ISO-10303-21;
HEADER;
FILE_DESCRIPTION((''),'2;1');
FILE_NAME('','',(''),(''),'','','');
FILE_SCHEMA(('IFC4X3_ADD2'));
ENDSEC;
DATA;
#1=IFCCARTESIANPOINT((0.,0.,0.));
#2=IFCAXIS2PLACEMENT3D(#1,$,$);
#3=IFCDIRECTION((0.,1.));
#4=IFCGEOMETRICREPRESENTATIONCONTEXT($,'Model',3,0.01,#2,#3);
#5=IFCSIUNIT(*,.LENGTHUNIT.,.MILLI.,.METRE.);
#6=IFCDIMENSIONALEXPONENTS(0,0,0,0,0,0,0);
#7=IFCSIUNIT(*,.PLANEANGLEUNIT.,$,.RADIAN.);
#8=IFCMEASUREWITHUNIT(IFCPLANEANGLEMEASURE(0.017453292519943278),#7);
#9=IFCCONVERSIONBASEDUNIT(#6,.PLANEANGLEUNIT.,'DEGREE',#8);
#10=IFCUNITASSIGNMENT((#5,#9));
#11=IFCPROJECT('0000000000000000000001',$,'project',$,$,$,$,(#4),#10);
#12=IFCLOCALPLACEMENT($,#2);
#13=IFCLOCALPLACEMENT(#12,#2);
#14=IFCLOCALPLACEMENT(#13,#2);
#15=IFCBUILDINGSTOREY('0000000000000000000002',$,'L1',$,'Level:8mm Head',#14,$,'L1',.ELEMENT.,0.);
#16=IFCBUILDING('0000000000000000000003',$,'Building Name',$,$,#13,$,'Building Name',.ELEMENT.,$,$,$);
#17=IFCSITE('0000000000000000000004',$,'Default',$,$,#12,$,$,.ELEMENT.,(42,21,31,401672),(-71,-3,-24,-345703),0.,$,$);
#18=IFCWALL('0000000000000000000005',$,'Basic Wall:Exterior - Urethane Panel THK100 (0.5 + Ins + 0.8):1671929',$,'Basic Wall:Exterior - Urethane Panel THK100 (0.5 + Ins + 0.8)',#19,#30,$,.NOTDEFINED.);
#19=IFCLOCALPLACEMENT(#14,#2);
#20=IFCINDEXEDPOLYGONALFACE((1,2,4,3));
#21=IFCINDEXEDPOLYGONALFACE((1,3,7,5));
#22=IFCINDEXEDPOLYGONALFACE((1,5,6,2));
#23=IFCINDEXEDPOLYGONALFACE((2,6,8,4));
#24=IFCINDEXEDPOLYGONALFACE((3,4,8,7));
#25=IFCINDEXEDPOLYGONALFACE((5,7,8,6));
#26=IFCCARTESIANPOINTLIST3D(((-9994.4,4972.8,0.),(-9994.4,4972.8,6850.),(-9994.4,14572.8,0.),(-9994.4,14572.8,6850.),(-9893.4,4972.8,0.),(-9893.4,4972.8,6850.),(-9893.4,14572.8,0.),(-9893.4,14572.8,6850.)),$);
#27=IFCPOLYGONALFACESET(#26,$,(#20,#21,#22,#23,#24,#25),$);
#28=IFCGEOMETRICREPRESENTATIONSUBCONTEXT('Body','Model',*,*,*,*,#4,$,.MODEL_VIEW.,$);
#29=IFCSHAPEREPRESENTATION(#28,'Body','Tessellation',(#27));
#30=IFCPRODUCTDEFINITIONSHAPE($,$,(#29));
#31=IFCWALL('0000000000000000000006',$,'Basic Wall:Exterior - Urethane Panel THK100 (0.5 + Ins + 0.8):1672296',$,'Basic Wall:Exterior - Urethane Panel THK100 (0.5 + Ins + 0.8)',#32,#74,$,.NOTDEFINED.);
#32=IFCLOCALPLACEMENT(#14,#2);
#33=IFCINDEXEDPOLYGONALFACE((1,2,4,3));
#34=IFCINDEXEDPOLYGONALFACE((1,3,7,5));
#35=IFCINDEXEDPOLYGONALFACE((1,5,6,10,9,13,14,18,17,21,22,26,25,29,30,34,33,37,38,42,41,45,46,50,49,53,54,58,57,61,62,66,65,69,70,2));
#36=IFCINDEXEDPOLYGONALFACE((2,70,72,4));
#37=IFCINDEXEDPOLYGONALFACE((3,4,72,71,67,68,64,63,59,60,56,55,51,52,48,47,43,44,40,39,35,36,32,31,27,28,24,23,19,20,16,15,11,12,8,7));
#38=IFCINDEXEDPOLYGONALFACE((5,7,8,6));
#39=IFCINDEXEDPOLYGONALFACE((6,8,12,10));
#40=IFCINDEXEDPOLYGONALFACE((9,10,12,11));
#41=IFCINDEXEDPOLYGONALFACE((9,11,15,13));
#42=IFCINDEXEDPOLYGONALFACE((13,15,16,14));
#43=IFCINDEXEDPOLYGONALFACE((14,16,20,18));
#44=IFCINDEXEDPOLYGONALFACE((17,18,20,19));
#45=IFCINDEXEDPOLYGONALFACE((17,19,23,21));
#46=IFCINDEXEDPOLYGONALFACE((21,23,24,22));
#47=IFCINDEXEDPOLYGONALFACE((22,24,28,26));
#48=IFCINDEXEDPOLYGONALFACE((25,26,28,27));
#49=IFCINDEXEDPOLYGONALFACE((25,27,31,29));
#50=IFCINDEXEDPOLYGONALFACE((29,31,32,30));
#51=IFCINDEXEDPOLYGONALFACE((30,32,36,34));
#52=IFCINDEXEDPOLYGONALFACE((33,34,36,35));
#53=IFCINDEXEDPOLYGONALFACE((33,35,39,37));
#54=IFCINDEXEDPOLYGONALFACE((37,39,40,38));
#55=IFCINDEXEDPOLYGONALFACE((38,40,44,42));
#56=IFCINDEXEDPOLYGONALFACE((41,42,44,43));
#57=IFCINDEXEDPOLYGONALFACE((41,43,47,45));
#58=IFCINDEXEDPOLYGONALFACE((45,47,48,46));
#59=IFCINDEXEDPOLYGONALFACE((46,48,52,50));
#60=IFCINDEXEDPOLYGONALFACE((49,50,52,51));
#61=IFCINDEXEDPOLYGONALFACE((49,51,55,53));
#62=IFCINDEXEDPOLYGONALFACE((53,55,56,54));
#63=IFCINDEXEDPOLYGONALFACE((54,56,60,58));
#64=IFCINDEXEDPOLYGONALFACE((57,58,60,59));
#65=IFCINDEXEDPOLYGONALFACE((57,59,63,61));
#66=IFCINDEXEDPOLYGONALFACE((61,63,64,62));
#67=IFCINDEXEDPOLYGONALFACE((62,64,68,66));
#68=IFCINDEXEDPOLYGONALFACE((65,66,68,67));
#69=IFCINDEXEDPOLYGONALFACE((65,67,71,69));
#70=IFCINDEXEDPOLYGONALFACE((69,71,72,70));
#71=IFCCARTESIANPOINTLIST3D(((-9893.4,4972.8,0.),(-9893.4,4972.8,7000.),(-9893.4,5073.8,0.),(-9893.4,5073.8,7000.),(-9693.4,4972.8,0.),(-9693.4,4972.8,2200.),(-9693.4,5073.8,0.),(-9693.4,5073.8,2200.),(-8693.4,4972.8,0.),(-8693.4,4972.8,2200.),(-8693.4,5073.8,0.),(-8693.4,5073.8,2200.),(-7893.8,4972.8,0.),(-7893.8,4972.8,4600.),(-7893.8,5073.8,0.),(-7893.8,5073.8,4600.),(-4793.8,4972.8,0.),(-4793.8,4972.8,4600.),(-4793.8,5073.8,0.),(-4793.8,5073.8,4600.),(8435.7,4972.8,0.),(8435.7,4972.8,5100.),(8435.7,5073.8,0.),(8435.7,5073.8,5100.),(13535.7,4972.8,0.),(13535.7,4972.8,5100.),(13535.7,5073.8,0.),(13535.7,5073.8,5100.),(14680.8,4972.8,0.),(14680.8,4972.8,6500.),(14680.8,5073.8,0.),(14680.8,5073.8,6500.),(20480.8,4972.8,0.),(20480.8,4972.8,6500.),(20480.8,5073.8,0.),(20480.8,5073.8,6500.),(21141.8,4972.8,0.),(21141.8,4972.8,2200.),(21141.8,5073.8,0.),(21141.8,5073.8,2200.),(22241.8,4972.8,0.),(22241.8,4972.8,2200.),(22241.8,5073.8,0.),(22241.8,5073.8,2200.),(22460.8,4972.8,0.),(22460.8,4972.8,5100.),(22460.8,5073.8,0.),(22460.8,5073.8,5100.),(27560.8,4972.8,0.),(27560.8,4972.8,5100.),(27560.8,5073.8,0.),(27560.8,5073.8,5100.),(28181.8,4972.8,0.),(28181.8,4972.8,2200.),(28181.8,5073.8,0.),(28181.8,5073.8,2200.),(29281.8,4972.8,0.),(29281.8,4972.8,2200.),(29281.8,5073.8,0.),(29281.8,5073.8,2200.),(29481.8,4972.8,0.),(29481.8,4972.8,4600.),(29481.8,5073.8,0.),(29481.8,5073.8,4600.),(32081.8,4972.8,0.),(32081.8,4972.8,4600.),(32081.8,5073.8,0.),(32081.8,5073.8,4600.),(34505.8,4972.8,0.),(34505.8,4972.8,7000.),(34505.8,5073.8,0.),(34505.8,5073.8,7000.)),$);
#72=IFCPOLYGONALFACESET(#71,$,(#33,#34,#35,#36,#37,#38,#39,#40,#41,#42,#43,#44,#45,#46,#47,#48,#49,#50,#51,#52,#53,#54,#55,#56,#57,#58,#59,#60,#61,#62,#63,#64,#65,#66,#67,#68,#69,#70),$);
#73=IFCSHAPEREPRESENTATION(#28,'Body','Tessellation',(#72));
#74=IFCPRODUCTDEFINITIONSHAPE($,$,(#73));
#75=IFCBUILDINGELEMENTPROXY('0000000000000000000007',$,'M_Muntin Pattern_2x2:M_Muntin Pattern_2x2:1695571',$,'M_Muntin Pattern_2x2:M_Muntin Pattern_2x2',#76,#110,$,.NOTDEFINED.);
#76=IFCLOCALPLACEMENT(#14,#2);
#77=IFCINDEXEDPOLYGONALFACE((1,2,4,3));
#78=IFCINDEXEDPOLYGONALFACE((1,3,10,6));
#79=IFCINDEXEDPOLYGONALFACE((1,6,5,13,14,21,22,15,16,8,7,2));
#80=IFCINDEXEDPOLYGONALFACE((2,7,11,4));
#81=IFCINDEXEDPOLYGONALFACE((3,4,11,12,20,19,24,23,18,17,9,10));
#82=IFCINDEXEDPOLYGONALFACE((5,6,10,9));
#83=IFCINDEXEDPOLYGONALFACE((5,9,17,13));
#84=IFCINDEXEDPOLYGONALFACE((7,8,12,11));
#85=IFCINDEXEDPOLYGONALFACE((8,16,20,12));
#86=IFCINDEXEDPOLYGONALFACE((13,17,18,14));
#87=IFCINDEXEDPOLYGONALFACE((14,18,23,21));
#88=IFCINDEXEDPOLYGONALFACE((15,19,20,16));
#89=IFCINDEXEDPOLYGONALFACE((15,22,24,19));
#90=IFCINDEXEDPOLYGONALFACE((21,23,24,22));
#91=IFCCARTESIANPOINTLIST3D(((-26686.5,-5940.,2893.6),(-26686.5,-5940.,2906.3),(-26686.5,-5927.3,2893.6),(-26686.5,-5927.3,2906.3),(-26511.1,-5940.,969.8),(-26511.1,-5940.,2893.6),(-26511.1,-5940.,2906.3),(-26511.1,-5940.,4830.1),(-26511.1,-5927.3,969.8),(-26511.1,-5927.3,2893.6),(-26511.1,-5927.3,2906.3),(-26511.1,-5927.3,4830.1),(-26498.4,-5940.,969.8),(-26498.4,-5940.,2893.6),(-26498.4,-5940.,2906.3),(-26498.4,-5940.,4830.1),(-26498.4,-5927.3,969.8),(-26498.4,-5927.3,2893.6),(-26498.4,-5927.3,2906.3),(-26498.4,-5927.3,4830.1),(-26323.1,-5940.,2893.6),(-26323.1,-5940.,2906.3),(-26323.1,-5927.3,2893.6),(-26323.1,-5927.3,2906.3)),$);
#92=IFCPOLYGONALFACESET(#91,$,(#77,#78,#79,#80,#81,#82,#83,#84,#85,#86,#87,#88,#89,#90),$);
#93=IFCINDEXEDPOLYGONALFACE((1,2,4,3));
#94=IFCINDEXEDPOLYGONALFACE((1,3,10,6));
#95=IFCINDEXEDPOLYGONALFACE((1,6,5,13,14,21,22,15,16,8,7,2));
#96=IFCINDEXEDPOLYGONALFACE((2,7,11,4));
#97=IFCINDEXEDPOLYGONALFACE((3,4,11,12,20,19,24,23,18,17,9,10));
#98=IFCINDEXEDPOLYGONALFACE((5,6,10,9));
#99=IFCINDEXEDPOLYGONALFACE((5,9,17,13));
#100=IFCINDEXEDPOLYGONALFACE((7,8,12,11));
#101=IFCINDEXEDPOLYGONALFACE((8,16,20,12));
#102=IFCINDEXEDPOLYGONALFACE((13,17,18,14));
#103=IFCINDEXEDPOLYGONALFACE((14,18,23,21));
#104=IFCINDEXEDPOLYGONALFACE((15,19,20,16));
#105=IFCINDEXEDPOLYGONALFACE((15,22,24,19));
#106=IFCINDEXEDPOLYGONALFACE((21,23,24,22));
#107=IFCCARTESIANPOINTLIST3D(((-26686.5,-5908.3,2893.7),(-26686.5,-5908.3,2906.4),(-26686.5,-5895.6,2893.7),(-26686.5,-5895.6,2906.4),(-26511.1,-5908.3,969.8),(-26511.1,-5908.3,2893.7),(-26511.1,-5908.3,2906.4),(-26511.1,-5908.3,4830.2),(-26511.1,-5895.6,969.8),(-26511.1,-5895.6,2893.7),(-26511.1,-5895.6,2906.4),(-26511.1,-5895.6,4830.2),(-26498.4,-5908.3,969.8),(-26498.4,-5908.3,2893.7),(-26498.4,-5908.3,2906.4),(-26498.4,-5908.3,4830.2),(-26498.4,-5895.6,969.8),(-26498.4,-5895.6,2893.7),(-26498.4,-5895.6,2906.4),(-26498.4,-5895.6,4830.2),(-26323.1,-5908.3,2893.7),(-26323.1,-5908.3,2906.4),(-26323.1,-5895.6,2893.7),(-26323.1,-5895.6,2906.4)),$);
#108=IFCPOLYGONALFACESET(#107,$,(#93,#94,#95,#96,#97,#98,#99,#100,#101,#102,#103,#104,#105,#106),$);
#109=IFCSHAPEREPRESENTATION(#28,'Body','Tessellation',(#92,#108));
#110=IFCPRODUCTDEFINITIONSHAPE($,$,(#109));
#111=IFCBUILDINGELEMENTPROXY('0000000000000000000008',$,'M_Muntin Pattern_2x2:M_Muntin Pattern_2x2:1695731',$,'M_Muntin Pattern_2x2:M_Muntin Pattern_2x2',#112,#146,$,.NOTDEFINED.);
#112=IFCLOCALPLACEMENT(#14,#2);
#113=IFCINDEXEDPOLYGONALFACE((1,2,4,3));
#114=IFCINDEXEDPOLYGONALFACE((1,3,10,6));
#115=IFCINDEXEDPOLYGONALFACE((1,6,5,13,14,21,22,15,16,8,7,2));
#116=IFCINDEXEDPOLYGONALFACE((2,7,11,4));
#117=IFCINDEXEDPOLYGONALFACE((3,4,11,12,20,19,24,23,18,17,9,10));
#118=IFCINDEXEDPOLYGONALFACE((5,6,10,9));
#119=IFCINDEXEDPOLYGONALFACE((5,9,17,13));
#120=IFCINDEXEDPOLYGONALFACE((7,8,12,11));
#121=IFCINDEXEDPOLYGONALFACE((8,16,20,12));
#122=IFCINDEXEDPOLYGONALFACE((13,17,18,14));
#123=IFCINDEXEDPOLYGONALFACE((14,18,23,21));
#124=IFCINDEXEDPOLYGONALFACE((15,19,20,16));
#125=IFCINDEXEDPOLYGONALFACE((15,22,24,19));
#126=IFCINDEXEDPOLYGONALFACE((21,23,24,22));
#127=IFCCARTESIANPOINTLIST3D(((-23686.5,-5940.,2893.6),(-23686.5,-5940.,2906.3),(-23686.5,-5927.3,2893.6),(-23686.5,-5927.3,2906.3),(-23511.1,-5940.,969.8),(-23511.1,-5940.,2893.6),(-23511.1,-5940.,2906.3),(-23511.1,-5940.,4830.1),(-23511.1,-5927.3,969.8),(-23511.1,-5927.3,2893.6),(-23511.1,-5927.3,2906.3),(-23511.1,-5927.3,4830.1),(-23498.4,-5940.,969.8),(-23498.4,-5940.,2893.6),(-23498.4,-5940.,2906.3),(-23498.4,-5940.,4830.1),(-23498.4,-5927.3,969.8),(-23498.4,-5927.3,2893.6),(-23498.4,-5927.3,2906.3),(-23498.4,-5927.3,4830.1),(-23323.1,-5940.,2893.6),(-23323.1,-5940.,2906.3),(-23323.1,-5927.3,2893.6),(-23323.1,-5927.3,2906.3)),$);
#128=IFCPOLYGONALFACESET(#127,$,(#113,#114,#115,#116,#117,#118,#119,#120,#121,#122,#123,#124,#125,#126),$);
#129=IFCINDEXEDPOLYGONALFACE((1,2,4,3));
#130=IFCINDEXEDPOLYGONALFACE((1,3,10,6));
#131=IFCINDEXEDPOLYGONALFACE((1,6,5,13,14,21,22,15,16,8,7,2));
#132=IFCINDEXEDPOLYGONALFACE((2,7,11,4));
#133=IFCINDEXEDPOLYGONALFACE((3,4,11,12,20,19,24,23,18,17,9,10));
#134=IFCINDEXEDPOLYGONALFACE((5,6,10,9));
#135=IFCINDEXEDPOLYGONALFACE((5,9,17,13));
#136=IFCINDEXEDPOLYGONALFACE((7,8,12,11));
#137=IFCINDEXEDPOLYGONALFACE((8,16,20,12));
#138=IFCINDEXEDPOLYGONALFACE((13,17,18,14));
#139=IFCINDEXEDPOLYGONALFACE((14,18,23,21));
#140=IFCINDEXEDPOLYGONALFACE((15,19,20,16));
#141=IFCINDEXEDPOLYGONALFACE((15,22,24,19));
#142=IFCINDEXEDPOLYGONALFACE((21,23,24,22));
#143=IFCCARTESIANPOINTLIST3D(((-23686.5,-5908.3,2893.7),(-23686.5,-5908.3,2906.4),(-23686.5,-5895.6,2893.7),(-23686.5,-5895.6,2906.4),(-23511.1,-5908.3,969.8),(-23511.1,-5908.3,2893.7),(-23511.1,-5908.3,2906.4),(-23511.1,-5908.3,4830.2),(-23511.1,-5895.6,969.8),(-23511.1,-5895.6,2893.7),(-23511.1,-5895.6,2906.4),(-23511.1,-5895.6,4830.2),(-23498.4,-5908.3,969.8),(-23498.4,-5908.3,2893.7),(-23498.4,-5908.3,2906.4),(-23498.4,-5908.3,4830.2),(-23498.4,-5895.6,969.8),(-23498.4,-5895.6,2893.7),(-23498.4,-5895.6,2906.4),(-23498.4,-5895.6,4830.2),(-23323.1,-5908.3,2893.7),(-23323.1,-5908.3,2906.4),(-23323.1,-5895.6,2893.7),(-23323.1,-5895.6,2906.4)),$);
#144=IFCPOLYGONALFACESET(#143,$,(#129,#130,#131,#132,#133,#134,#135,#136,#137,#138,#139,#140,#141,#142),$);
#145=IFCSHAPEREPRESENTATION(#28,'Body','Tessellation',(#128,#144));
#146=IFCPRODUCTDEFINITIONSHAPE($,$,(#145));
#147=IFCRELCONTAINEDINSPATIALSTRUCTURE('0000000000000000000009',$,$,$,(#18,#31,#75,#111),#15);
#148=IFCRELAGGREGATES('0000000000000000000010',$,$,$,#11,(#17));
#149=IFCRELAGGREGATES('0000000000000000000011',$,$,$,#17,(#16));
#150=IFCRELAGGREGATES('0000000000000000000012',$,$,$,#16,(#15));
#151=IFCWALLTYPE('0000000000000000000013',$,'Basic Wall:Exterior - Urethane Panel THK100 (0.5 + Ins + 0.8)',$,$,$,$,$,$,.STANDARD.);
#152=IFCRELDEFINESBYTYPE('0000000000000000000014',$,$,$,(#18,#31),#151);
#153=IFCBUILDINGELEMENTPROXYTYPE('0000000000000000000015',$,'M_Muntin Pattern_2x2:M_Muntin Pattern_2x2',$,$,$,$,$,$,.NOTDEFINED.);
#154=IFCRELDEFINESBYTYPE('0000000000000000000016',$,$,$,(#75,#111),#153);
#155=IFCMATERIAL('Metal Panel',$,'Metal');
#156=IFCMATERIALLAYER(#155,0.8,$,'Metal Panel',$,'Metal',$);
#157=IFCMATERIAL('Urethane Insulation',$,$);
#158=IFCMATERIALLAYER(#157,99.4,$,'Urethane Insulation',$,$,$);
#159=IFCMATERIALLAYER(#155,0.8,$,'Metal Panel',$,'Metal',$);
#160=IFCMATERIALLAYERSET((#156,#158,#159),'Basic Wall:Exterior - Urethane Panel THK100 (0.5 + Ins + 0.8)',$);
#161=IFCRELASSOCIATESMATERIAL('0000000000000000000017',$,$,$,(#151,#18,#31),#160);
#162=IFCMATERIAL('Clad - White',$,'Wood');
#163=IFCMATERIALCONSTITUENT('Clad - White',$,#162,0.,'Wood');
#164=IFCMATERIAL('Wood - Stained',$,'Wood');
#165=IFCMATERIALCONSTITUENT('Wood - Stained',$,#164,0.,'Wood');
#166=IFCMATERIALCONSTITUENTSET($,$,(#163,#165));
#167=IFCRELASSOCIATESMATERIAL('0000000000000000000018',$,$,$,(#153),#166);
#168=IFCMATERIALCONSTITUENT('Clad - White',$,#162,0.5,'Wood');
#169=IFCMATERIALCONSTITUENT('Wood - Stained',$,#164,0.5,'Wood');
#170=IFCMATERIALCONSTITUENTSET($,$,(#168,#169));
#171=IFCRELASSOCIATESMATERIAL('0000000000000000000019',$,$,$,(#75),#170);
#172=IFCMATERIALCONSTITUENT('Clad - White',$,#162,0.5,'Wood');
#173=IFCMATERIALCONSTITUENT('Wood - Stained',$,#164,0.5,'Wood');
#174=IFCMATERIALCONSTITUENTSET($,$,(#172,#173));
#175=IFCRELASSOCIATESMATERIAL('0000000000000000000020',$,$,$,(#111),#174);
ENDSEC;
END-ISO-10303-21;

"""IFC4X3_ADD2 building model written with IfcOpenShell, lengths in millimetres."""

from ifc_helpers import new_model, entity, si_unit, converted_unit, direction, frame, frame_2d, origin, place, context, subcontext, project, spatial, polyline, rectangle, outline, extrude, clip, bounded_halfspace, source, transform, mapped, material, layer, layer_set, constituent, constituent_set, type_object, type_shapes, element, save


model = new_model("IFC4X3_ADD2")

# Units and contexts
model_context = context("Model", 3, precision=0.01, world=origin(), true_north=direction((0.0, 1.0)))
body_context = subcontext(model_context, "Body", "Model", "MODEL_VIEW")
ifc_project = project(units=[si_unit("LENGTHUNIT", "METRE", prefix="MILLI"), converted_unit("PLANEANGLEUNIT", "DEGREE", entity("IfcPlaneAngleMeasure", 0.017453292519943278), si_unit("PLANEANGLEUNIT", "RADIAN"), dimensions=[0, 0, 0, 0, 0, 0, 0])], contexts=[model_context])

# Site, building, storey
site_placement = place(None, origin())
site = spatial("IfcSite", under=ifc_project, at=site_placement, Name="Default", CompositionType="ELEMENT", RefLatitude=(42, 21, 31, 401672), RefLongitude=(-71, -3, -24, -345703), RefElevation=0.0)
building_placement = place(site_placement, origin())
building = spatial("IfcBuilding", under=site, at=building_placement, Name="Building Name", LongName="Building Name", CompositionType="ELEMENT")
storey_placement = place(building_placement, origin())
storey = spatial("IfcBuildingStorey", under=building, at=storey_placement, Name="L1", ObjectType="Level:8mm Head", LongName="L1", CompositionType="ELEMENT", Elevation=0.0)

# Wall
ifc_material_1 = material(Name="Metal Panel", Category="Metal")
ifc_layer_1 = layer(ifc_material_1, 0.8, Name="Metal Panel", Category="Metal")
ifc_material_2 = material(Name="Urethane Insulation")
ifc_layer_2 = layer(ifc_material_2, 99.4, Name="Urethane Insulation")
ifc_layer_3 = layer(ifc_material_1, 0.8, Name="Metal Panel", Category="Metal")
ifc_layer_set = layer_set([ifc_layer_1, ifc_layer_2, ifc_layer_3], Name="Basic Wall:Exterior - Urethane Panel THK100 (0.5 + Ins + 0.8)")
wall_type = type_object("IfcWallType", Name="Basic Wall:Exterior - Urethane Panel THK100 (0.5 + Ins + 0.8)", PredefinedType="STANDARD", material=ifc_layer_set)
wall_1_placement = place(storey_placement, frame((-9943.9, 4972.8, 0.0), z_axis=(0.0, 0.0, 1.0), x_axis=(0.0, 1.0, 0.0)))
element("IfcWall", 1, at=wall_1_placement, inside=storey, type_object=wall_type, material=ifc_layer_set, Name="Basic Wall:Exterior - Urethane Panel THK100 (0.5 + Ins + 0.8):1671929", ObjectType="Basic Wall:Exterior - Urethane Panel THK100 (0.5 + Ins + 0.8)", PredefinedType="NOTDEFINED", context=body_context, shape_type="Clipping", body=[
    clip(extrude(rectangle(XDim=9600.0, YDim=101.0, at=frame_2d((4800.0, 0.0), x_axis=(-1.0, 0.0))), origin(), (0.0, 0.0, 1.0), 6850.0), bounded_halfspace(frame((0.0, -50.5, 6850.0), z_axis=(0.0, 0.0, -1.0), x_axis=(0.0, -1.0, 0.0)), True, frame((0.0, -50.5, 6850.0)), polyline([(0.0, 0.0), (9600.0, 0.0), (9600.0, 101.0), (0.0, 101.0), (0.0, 0.0)]))),
])

# Wall, openings
wall_2_placement = place(storey_placement, frame((-9893.4, 5023.3, 0.0)))
wall_2 = element("IfcWall", 2, at=wall_2_placement, inside=storey, type_object=wall_type, material=ifc_layer_set, Name="Basic Wall:Exterior - Urethane Panel THK100 (0.5 + Ins + 0.8):1672296", ObjectType="Basic Wall:Exterior - Urethane Panel THK100 (0.5 + Ins + 0.8)", PredefinedType="NOTDEFINED", context=body_context, shape_type="SweptSolid", body=[
    extrude(rectangle(XDim=44399.2, YDim=101.0, at=frame_2d((22199.6, 0.0), x_axis=(-1.0, 0.0))), origin(), (0.0, 0.0, 1.0), 7000.0),
])
opening_1_placement = place(wall_2_placement, frame((200.0, -50.5, 0.0)))
element("IfcOpeningElement", 3, at=opening_1_placement, cuts=wall_2, PredefinedType="OPENING", context=body_context, shape_type="SweptSolid", body=[
    extrude(rectangle(XDim=2200.0, YDim=1000.0, at=frame_2d((1100.0, 500.0), x_axis=(1.0, 0.0))), frame((0.0, 0.0, 0.0), z_axis=(0.0, 1.0, 0.0), x_axis=(0.0, 0.0, 1.0)), (0.0, 0.0, 1.0), 101.0),
])
opening_2_placement = place(wall_2_placement, frame((39175.2, 50.5, 0.0)))
element("IfcOpeningElement", 4, at=opening_2_placement, cuts=wall_2, PredefinedType="OPENING", context=body_context, shape_type="SweptSolid", body=[
    extrude(rectangle(XDim=2200.0, YDim=1100.0, at=frame_2d((1100.0, 550.0), x_axis=(1.0, 0.0))), frame((0.0, 0.0, 0.0), z_axis=(0.0, -1.0, 0.0), x_axis=(0.0, 0.0, 1.0)), (0.0, 0.0, 1.0), 101.0),
])
opening_3_placement = place(wall_2_placement, frame((32135.2, 50.5, 0.0)))
element("IfcOpeningElement", 5, at=opening_3_placement, cuts=wall_2, PredefinedType="OPENING", context=body_context, shape_type="SweptSolid", body=[
    extrude(rectangle(XDim=2200.0, YDim=1100.0, at=frame_2d((1100.0, 550.0), x_axis=(1.0, 0.0))), frame((0.0, 0.0, 0.0), z_axis=(0.0, -1.0, 0.0), x_axis=(0.0, 0.0, 1.0)), (0.0, 0.0, 1.0), 101.0),
])
opening_4_placement = place(wall_2_placement, frame((18329.1, -50.5, 0.0)))
element("IfcOpeningElement", 6, at=opening_4_placement, cuts=wall_2, PredefinedType="OPENING", context=body_context, shape_type="SweptSolid", body=[
    extrude(rectangle(XDim=5100.0, YDim=5100.0, at=frame_2d((2550.0, 2550.0), x_axis=(1.0, 0.0))), frame((0.0, 0.0, 0.0), z_axis=(0.0, 1.0, 0.0), x_axis=(0.0, 0.0, 1.0)), (0.0, 0.0, 1.0), 101.0),
])
opening_5_placement = place(wall_2_placement, frame((37454.2, 50.5, 0.0)))
element("IfcOpeningElement", 7, at=opening_5_placement, cuts=wall_2, PredefinedType="OPENING", context=body_context, shape_type="SweptSolid", body=[
    extrude(rectangle(XDim=5100.0, YDim=5100.0, at=frame_2d((2550.0, 2550.0), x_axis=(1.0, 0.0))), frame((0.0, 0.0, 0.0), z_axis=(0.0, -1.0, 0.0), x_axis=(0.0, 0.0, 1.0)), (0.0, 0.0, 1.0), 101.0),
])
opening_6_placement = place(wall_2_placement, frame((41975.2, 50.5, 0.0)))
element("IfcOpeningElement", 8, at=opening_6_placement, cuts=wall_2, PredefinedType="OPENING", context=body_context, shape_type="SweptSolid", body=[
    extrude(rectangle(XDim=4600.0, YDim=2600.0, at=frame_2d((2300.0, 1300.0), x_axis=(1.0, 0.0))), frame((0.0, 0.0, 0.0), z_axis=(0.0, -1.0, 0.0), x_axis=(0.0, 0.0, 1.0)), (0.0, 0.0, 1.0), 101.0),
])
opening_7_placement = place(wall_2_placement, frame((5099.6, 50.5, 0.0)))
element("IfcOpeningElement", 9, at=opening_7_placement, cuts=wall_2, PredefinedType="OPENING", context=body_context, shape_type="SweptSolid", body=[
    extrude(rectangle(XDim=4600.0, YDim=3100.0, at=frame_2d((2300.0, 1550.0), x_axis=(1.0, 0.0))), frame((0.0, 0.0, 0.0), z_axis=(0.0, -1.0, 0.0), x_axis=(0.0, 0.0, 1.0)), (0.0, 0.0, 1.0), 101.0),
])
opening_8_placement = place(wall_2_placement, frame((30374.2, 50.5, 0.0)))
element("IfcOpeningElement", 10, at=opening_8_placement, cuts=wall_2, PredefinedType="OPENING", context=body_context, shape_type="SweptSolid", body=[
    extrude(rectangle(XDim=6500.0, YDim=5800.0, at=frame_2d((3250.0, 2900.0), x_axis=(-1.0, 0.0))), frame((0.0, 0.0, 0.0), z_axis=(0.0, -1.0, 0.0), x_axis=(0.0, 0.0, 1.0)), (0.0, 0.0, 1.0), 101.0),
])

# Building element proxies
ifc_material_3 = material(Name="Clad - White", Category="Wood")
ifc_constituent_1 = constituent(ifc_material_3, Name="Clad - White", Category="Wood", fraction=0.5)
ifc_material_4 = material(Name="Wood - Stained", Category="Wood")
ifc_constituent_2 = constituent(ifc_material_4, Name="Wood - Stained", Category="Wood", fraction=0.5)
ifc_constituent_set_1 = constituent_set(constituents=[ifc_constituent_1, ifc_constituent_2])
ifc_constituent_3 = constituent(ifc_material_3, Name="Clad - White", Category="Wood", fraction=0.0)
ifc_constituent_4 = constituent(ifc_material_4, Name="Wood - Stained", Category="Wood", fraction=0.0)
ifc_constituent_set_2 = constituent_set(constituents=[ifc_constituent_3, ifc_constituent_4])
building_element_proxy_type_1 = type_object("IfcBuildingElementProxyType", Name="M_Muntin Pattern_2x2:M_Muntin Pattern_2x2", PredefinedType="NOTDEFINED", material=ifc_constituent_set_2)
shared_shape_1 = source(origin(), body_context, "Body", "SweptSolid", [
    extrude(outline(polyline([(6.4, -6.4), (1930.1, -6.4), (1930.1, 6.3), (6.4, 6.3), (6.4, 181.7), (-6.3, 181.7), (-6.3, 6.3), (-1930.2, 6.3), (-1930.2, -6.4), (-6.3, -6.4), (-6.3, -181.7), (6.4, -181.7), (6.4, -6.4)])), frame((0.0, 9.5, 1930.1), z_axis=(0.0, 1.0, 0.0), x_axis=(0.0, 0.0, 1.0)), (0.0, 0.0, 1.0), 12.7),
    extrude(outline(polyline([(6.4, -6.4), (1930.2, -6.4), (1930.2, 6.3), (6.4, 6.3), (6.4, 181.7), (-6.3, 181.7), (-6.3, 6.3), (-1930.2, 6.3), (-1930.2, -6.4), (-6.3, -6.4), (-6.3, -181.7), (6.4, -181.7), (6.4, -6.4)])), frame((0.0, -22.2, 1930.2), z_axis=(0.0, 1.0, 0.0), x_axis=(0.0, 0.0, 1.0)), (0.0, 0.0, 1.0), 12.7),
])
type_shapes(building_element_proxy_type_1, [shared_shape_1])
proxy_1_placement = place(storey_placement, frame((-26504.8, -5917.8, 969.8), z_axis=(0.0, 0.0, 1.0), x_axis=(-1.0, 0.0, 0.0)))
element("IfcBuildingElementProxy", 11, at=proxy_1_placement, inside=storey, type_object=building_element_proxy_type_1, material=ifc_constituent_set_1, Name="M_Muntin Pattern_2x2:M_Muntin Pattern_2x2:1695571", ObjectType="M_Muntin Pattern_2x2:M_Muntin Pattern_2x2", PredefinedType="NOTDEFINED", context=body_context, shape_type="MappedRepresentation", body=[
    mapped(shared_shape_1, transform((0.0, 0.0, 0.0), scale=1.0)),
])
ifc_constituent_5 = constituent(ifc_material_3, Name="Clad - White", Category="Wood", fraction=0.5)
ifc_constituent_6 = constituent(ifc_material_4, Name="Wood - Stained", Category="Wood", fraction=0.5)
ifc_constituent_set_3 = constituent_set(constituents=[ifc_constituent_5, ifc_constituent_6])
proxy_2_placement = place(storey_placement, frame((-23504.8, -5917.8, 969.8), z_axis=(0.0, 0.0, 1.0), x_axis=(-1.0, 0.0, 0.0)))
element("IfcBuildingElementProxy", 12, at=proxy_2_placement, inside=storey, type_object=building_element_proxy_type_1, material=ifc_constituent_set_3, Name="M_Muntin Pattern_2x2:M_Muntin Pattern_2x2:1695731", ObjectType="M_Muntin Pattern_2x2:M_Muntin Pattern_2x2", PredefinedType="NOTDEFINED", context=body_context, shape_type="MappedRepresentation", body=[
    mapped(shared_shape_1, transform((0.0, 0.0, 0.0), scale=1.0)),
])

save(model, "model.ifc")
